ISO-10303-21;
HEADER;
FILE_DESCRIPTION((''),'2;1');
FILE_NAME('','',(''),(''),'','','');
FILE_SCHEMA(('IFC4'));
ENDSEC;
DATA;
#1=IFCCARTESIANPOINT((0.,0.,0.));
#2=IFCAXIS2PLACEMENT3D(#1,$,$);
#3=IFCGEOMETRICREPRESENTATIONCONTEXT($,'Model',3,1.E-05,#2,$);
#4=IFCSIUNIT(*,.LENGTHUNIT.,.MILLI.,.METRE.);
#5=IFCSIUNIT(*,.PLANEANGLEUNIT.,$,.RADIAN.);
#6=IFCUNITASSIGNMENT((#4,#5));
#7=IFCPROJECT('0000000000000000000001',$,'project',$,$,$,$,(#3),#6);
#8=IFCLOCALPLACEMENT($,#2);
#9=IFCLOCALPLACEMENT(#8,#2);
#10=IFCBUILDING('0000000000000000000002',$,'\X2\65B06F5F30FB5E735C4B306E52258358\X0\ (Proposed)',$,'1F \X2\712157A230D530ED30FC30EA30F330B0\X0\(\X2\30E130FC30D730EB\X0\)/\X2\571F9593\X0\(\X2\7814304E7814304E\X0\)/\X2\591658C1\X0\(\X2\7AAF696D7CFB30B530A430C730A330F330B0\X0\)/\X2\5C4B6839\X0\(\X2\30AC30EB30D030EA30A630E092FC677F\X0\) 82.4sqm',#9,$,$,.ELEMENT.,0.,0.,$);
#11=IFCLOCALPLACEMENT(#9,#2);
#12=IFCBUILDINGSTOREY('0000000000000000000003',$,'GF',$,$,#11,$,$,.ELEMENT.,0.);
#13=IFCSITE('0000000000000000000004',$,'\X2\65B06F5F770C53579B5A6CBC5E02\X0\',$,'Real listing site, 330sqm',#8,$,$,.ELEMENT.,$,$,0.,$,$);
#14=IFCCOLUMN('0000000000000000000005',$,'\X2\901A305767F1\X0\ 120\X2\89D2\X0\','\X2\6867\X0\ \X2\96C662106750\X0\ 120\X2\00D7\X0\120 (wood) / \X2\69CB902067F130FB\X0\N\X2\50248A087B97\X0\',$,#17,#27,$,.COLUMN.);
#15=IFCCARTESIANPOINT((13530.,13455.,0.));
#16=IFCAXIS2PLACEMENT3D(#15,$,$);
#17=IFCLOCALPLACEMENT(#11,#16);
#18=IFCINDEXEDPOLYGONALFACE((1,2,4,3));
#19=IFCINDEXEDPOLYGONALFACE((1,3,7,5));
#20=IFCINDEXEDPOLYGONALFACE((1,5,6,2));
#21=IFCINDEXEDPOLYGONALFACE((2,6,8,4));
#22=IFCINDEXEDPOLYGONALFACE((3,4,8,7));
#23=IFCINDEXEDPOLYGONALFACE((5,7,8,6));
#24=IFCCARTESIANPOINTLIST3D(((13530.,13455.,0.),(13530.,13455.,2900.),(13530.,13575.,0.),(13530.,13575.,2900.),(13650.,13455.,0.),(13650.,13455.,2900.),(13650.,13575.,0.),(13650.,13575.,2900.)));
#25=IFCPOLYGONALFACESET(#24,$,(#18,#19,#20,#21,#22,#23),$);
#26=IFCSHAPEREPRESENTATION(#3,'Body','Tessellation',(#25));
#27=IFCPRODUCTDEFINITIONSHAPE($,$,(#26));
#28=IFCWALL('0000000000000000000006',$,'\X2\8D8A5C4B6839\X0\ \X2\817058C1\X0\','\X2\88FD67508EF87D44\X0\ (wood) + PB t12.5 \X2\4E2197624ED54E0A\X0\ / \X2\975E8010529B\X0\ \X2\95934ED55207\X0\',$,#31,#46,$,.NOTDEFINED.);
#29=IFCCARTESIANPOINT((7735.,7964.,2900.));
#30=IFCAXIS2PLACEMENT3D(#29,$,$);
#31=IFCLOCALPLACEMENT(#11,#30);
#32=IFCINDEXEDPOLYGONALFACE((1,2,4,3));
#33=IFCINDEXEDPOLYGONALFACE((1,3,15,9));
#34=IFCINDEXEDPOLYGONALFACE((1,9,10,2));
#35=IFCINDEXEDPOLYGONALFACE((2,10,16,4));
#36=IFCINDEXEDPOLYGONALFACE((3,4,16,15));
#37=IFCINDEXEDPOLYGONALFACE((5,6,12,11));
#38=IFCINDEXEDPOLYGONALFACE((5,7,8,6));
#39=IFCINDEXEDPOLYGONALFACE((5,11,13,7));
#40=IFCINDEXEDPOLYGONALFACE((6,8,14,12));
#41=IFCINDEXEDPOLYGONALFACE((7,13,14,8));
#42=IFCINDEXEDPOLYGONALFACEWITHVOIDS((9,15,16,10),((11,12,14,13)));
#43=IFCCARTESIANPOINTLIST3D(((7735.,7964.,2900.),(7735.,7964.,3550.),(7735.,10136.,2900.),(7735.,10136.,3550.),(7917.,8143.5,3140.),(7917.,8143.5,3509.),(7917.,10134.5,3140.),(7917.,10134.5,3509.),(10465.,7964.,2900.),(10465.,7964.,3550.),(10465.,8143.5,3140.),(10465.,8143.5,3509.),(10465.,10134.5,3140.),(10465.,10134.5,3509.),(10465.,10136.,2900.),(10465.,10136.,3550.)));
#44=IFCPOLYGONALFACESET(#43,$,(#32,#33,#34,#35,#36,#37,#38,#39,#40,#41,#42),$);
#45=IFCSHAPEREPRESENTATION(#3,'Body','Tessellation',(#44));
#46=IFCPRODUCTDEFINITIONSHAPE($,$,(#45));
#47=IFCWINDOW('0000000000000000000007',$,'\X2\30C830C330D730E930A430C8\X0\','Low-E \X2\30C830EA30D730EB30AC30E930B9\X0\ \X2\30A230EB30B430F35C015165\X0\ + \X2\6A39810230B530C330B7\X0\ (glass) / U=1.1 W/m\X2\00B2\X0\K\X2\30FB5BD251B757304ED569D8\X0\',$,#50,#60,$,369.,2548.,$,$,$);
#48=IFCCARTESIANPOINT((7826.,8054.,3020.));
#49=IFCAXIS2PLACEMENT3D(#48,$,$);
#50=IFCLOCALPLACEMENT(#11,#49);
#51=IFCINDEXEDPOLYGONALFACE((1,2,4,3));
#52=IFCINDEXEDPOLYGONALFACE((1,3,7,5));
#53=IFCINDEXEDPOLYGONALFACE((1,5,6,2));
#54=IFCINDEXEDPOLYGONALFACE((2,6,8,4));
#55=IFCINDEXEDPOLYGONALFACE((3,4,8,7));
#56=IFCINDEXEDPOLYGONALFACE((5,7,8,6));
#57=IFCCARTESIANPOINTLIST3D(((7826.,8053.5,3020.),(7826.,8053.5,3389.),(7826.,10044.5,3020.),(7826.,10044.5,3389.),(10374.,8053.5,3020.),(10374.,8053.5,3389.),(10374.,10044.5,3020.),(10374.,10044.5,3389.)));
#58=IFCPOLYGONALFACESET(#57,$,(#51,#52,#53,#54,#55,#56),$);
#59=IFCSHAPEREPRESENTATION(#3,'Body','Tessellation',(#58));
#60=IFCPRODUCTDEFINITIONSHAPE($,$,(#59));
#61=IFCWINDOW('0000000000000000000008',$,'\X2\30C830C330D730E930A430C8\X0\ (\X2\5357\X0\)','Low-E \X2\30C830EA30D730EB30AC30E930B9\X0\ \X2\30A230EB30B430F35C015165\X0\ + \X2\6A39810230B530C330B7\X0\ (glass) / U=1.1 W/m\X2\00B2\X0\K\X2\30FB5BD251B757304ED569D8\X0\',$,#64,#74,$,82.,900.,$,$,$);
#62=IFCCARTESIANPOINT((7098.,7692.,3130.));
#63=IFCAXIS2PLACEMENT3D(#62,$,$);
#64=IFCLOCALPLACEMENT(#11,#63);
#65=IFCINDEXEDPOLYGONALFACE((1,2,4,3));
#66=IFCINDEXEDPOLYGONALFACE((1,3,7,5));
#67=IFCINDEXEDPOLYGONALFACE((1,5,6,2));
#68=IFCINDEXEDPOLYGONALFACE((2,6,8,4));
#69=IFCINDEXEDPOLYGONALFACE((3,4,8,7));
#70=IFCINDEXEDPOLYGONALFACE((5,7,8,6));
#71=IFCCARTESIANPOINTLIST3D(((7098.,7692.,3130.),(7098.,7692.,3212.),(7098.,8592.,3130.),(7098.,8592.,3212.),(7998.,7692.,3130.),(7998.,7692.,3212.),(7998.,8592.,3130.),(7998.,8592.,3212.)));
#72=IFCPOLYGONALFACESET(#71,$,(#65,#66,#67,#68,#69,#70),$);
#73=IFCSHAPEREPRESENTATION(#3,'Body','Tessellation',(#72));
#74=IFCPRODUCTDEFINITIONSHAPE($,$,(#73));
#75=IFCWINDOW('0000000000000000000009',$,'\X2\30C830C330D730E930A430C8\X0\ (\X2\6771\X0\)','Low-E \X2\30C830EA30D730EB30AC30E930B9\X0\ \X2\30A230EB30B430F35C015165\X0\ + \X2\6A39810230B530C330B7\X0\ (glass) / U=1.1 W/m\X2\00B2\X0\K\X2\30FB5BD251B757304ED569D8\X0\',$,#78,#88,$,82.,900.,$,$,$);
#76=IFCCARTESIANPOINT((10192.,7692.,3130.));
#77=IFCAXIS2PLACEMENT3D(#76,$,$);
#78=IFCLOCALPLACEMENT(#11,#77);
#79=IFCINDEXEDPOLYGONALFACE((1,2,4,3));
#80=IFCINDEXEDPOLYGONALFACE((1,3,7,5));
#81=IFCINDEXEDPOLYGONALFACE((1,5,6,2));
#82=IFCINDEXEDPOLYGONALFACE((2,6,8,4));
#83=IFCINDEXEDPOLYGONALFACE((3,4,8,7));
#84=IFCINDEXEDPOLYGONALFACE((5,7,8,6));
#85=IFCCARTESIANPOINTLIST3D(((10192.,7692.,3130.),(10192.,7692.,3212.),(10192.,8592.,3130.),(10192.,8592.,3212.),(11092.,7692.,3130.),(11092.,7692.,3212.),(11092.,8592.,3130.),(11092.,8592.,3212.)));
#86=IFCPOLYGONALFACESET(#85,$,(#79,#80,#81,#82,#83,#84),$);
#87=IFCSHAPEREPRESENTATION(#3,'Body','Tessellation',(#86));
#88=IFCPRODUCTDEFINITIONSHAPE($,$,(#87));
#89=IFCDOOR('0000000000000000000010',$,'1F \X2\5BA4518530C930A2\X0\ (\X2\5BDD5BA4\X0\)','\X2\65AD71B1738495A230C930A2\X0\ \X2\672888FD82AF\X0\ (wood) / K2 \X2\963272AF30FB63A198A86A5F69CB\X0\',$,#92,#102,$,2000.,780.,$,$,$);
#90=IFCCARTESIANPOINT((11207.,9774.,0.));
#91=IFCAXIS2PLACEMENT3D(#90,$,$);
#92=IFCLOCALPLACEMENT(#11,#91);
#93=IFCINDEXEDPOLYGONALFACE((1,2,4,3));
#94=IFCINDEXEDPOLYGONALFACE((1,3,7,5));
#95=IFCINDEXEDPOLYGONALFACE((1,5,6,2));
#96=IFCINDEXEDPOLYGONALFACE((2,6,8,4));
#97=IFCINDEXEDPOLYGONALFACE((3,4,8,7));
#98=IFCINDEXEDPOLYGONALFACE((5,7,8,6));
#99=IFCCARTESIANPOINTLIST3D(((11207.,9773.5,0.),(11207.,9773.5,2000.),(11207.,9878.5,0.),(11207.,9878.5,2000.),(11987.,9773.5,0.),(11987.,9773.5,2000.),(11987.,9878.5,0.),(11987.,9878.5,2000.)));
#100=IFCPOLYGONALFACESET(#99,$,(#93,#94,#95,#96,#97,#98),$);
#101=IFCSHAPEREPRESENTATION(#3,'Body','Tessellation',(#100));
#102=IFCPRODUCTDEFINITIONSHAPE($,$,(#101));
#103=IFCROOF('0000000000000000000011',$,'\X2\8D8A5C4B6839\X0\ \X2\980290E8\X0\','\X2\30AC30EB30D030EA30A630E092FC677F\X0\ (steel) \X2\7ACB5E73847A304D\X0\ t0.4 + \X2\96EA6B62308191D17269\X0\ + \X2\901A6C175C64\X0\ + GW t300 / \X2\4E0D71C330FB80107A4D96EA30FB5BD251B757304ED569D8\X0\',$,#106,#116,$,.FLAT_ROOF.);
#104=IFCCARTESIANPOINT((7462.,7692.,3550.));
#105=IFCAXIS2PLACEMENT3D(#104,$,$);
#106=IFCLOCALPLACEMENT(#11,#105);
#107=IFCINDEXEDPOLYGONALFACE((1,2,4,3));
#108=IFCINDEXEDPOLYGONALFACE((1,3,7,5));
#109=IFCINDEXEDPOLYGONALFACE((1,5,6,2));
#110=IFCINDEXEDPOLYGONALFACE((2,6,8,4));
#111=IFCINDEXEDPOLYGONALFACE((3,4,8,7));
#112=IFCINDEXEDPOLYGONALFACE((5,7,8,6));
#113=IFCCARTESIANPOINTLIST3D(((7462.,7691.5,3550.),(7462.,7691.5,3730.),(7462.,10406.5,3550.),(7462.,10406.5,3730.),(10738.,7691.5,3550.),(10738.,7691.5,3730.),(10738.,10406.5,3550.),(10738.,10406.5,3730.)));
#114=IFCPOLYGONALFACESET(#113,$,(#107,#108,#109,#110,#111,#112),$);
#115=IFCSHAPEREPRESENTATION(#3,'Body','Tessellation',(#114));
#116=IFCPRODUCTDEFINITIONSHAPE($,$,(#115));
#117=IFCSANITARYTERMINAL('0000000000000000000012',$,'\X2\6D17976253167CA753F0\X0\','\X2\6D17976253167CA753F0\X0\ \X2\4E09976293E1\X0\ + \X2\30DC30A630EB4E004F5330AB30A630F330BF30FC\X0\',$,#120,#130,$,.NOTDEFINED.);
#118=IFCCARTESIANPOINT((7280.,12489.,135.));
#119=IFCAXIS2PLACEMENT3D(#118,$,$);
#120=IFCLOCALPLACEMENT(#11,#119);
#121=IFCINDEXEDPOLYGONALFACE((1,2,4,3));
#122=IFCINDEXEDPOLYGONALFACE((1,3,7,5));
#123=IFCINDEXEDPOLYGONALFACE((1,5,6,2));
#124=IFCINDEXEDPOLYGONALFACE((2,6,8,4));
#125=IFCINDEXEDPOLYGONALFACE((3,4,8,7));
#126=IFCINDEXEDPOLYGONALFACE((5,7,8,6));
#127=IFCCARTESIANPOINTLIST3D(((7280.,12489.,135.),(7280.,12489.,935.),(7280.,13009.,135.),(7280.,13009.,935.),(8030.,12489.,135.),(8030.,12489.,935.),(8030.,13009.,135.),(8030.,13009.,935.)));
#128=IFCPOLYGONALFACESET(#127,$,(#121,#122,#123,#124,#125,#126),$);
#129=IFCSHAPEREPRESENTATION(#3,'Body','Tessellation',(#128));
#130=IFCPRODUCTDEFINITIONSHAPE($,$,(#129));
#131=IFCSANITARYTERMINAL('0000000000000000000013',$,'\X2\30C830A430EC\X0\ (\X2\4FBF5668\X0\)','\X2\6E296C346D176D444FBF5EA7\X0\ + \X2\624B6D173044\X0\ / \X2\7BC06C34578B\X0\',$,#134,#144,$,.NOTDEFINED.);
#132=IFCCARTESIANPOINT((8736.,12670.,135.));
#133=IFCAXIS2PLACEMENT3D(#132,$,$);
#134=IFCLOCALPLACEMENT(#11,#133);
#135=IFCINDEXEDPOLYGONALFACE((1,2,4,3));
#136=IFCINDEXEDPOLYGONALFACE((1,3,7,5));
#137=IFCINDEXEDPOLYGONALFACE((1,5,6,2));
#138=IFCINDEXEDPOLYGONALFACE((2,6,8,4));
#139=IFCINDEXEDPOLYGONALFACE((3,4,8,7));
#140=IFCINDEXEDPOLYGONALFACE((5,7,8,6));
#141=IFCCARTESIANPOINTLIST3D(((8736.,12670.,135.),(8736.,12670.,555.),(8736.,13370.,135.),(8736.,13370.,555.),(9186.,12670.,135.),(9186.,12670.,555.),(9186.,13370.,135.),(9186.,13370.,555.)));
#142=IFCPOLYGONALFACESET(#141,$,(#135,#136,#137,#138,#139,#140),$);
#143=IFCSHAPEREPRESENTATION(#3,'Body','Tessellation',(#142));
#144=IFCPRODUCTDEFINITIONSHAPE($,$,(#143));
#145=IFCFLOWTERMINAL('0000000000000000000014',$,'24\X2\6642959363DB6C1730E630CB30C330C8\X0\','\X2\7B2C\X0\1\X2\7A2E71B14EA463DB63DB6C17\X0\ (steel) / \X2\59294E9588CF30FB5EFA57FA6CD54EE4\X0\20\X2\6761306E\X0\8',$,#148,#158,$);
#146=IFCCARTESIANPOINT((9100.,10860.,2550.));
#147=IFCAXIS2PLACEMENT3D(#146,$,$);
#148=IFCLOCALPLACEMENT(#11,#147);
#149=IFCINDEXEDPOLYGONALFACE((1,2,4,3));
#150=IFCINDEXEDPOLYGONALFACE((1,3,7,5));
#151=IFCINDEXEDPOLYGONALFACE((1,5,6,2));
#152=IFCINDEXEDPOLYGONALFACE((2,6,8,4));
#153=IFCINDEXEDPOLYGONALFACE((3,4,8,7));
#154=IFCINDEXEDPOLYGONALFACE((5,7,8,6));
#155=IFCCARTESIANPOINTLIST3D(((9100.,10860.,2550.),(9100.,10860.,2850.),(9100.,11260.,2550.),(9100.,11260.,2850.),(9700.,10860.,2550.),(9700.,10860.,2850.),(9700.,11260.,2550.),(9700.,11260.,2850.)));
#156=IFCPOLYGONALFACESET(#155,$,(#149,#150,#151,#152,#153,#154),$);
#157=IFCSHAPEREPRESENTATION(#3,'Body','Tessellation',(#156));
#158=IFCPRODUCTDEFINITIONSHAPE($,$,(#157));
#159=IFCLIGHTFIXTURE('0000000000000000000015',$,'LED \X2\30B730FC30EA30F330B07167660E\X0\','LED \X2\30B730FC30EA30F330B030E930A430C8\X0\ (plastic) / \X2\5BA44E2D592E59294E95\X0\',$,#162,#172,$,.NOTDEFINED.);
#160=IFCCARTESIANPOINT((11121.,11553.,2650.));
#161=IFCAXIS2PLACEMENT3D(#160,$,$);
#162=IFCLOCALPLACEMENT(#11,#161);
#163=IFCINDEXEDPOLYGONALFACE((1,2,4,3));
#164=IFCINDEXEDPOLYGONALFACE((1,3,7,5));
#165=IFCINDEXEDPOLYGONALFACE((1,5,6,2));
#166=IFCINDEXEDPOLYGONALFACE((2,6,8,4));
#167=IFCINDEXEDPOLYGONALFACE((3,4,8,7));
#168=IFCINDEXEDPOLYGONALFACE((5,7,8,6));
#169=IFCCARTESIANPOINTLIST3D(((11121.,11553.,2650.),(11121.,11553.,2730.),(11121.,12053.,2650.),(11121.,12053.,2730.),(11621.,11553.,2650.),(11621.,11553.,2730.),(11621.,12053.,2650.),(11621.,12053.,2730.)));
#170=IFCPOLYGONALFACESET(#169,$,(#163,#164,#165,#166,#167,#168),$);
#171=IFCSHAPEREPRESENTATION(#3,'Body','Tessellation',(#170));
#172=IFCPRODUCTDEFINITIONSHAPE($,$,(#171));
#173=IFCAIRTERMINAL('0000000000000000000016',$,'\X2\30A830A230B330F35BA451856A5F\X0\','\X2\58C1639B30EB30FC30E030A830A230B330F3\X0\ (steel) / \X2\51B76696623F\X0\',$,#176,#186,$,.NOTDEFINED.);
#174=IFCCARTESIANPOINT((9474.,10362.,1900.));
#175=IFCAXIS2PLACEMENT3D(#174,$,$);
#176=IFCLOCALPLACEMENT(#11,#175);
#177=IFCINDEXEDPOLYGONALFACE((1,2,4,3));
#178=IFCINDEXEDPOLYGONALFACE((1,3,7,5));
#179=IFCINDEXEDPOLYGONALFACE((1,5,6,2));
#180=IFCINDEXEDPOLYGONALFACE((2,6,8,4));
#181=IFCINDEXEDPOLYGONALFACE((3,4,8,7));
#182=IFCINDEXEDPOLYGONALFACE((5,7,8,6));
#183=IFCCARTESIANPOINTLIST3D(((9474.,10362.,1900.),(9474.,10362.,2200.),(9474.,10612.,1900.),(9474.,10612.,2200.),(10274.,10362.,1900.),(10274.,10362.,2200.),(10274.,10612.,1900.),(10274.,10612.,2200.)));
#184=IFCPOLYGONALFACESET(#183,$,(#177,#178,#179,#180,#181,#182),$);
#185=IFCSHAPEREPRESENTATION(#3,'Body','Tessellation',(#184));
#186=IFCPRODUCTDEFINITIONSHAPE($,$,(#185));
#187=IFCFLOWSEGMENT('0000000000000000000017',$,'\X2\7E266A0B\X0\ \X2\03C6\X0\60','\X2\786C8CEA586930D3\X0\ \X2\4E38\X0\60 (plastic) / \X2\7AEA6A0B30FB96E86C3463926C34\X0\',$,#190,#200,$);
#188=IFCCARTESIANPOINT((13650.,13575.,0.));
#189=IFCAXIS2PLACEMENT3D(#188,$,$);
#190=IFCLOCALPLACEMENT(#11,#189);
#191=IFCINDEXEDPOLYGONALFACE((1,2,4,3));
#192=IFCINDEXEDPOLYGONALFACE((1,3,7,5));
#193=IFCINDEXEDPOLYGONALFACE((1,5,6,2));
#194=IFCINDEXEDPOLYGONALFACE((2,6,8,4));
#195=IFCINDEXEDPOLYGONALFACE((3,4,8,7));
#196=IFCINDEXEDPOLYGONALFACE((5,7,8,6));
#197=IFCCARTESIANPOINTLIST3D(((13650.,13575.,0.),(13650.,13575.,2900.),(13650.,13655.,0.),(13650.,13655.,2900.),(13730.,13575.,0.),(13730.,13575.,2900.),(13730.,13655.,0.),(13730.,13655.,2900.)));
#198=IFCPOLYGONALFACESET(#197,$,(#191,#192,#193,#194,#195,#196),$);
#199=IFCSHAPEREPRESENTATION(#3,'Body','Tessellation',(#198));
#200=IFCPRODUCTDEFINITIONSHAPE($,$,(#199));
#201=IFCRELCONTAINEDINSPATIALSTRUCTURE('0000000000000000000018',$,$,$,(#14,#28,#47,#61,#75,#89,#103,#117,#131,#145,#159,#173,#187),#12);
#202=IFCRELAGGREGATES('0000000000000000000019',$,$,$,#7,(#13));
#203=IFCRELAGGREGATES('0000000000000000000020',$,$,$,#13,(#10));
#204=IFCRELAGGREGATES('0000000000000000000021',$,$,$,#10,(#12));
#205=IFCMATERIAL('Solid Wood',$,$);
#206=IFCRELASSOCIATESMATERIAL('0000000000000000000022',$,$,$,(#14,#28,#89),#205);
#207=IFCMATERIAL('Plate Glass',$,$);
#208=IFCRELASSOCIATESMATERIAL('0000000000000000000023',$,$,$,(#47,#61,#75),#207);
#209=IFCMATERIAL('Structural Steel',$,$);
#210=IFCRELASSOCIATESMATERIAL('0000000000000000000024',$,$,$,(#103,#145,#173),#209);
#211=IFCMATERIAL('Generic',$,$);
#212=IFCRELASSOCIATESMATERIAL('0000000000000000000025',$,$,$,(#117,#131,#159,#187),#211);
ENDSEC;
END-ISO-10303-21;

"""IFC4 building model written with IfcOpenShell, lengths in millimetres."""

from ifc_helpers import new_model, si_unit, frame, frame_2d, origin, place, context, project, spatial, rectangle, extrude, material, element, fill, save


model = new_model("IFC4")

# Units and contexts
model_context = context("Model", 3, precision=1e-05, world=origin())
ifc_project = project(units=[si_unit("LENGTHUNIT", "METRE", prefix="MILLI"), si_unit("PLANEANGLEUNIT", "RADIAN")], contexts=[model_context])

# Site, building, storey
site_placement = place(None, origin())
site = spatial("IfcSite", under=ifc_project, at=site_placement, Name="新潟県南魚沼市", ObjectType="Real listing site, 330sqm", CompositionType="ELEMENT", RefElevation=0.0)
building_placement = place(site_placement, origin())
building = spatial("IfcBuilding", under=site, at=building_placement, Name="新潟・平屋の別荘 (Proposed)", ObjectType="1F 無垢フローリング(メープル)/土間(研ぎ研ぎ)/外壁(窯業系サイディング)/屋根(ガルバリウム鋼板) 82.4sqm", CompositionType="ELEMENT", ElevationOfRefHeight=0.0, ElevationOfTerrain=0.0)
storey_placement = place(building_placement, origin())
storey = spatial("IfcBuildingStorey", under=building, at=storey_placement, Name="GF", CompositionType="ELEMENT", Elevation=0.0)

# Column
ifc_material_1 = material(Name="Solid Wood")
column_1_placement = place(storey_placement, frame((13530.0, 13455.0, 0.0)))
element("IfcColumn", 1, at=column_1_placement, inside=storey, material=ifc_material_1, Name="通し柱 120角", Description="桧 集成材 120×120 (wood) / 構造柱・N値計算", PredefinedType="COLUMN", context=model_context, shape_type="SweptSolid", body=[
    extrude(rectangle(XDim=120.0, YDim=120.0, at=frame_2d((60.0, 60.0))), frame((13530.0, 13455.0, 0.0)), (0.0, 0.0, 1.0), 2900.0),
])

# Wall, openings, windows
wall_1_placement = place(storey_placement, frame((7735.0, 7964.0, 2900.0)))
wall_1 = element("IfcWall", 2, at=wall_1_placement, inside=storey, material=ifc_material_1, Name="越屋根 腰壁", Description="製材軸組 (wood) + PB t12.5 両面仕上 / 非耐力 間仕切", PredefinedType="NOTDEFINED", context=model_context, shape_type="SweptSolid", body=[
    extrude(rectangle(XDim=2730.0, YDim=2172.0, at=frame_2d((1365.0, 1086.0))), frame((7735.0, 7964.0, 2900.0)), (0.0, 0.0, 1.0), 650.0),
])
opening_1_placement = place(storey_placement, frame((7826.0, 8054.0, 3020.0)))
opening_1 = element("IfcOpeningElement", 3, at=opening_1_placement, cuts=wall_1, PredefinedType="NOTDEFINED", context=model_context, shape_type="SweptSolid", body=[
    extrude(rectangle(XDim=2548.0, YDim=1991.0, at=frame_2d((1274.0, 995.0))), frame((7826.0, 8054.0, 3020.0)), (0.0, 0.0, 1.0), 369.0),
])
opening_2_placement = place(storey_placement, frame((7098.0, 7692.0, 3130.0)))
opening_2 = element("IfcOpeningElement", 4, at=opening_2_placement, cuts=wall_1, PredefinedType="NOTDEFINED", context=model_context, shape_type="SweptSolid", body=[
    extrude(rectangle(XDim=900.0, YDim=900.0, at=frame_2d((450.0, 450.0))), frame((7098.0, 7692.0, 3130.0)), (0.0, 0.0, 1.0), 82.0),
])
opening_3_placement = place(storey_placement, frame((10192.0, 7692.0, 3130.0)))
opening_3 = element("IfcOpeningElement", 5, at=opening_3_placement, cuts=wall_1, PredefinedType="NOTDEFINED", context=model_context, shape_type="SweptSolid", body=[
    extrude(rectangle(XDim=900.0, YDim=900.0, at=frame_2d((450.0, 450.0))), frame((10192.0, 7692.0, 3130.0)), (0.0, 0.0, 1.0), 82.0),
])
ifc_material_2 = material(Name="Plate Glass")
window_1_placement = place(storey_placement, frame((7826.0, 8054.0, 3020.0)))
window_1 = element("IfcWindow", 6, at=window_1_placement, inside=storey, material=ifc_material_2, Name="トップライト", Description="Low-E トリプルガラス アルゴン封入 + 樹脂サッシ (glass) / U=1.1 W/m²K・寒冷地仕様", OverallHeight=369.0, OverallWidth=2548.0, context=model_context, shape_type="SweptSolid", body=[
    extrude(rectangle(XDim=2548.0, YDim=1991.0, at=frame_2d((1274.0, 995.0))), frame((7826.0, 8054.0, 3020.0)), (0.0, 0.0, 1.0), 369.0),
])
fill(opening_1, window_1)
window_2_placement = place(storey_placement, frame((7098.0, 7692.0, 3130.0)))
window_2 = element("IfcWindow", 7, at=window_2_placement, inside=storey, material=ifc_material_2, Name="トップライト (南)", Description="Low-E トリプルガラス アルゴン封入 + 樹脂サッシ (glass) / U=1.1 W/m²K・寒冷地仕様", OverallHeight=82.0, OverallWidth=900.0, context=model_context, shape_type="SweptSolid", body=[
    extrude(rectangle(XDim=900.0, YDim=900.0, at=frame_2d((450.0, 450.0))), frame((7098.0, 7692.0, 3130.0)), (0.0, 0.0, 1.0), 82.0),
])
fill(opening_2, window_2)
window_3_placement = place(storey_placement, frame((10192.0, 7692.0, 3130.0)))
window_3 = element("IfcWindow", 8, at=window_3_placement, inside=storey, material=ifc_material_2, Name="トップライト (東)", Description="Low-E トリプルガラス アルゴン封入 + 樹脂サッシ (glass) / U=1.1 W/m²K・寒冷地仕様", OverallHeight=82.0, OverallWidth=900.0, context=model_context, shape_type="SweptSolid", body=[
    extrude(rectangle(XDim=900.0, YDim=900.0, at=frame_2d((450.0, 450.0))), frame((10192.0, 7692.0, 3130.0)), (0.0, 0.0, 1.0), 82.0),
])
fill(opening_3, window_3)

# Door
door_placement = place(storey_placement, frame((11207.0, 9774.0, 0.0)))
element("IfcDoor", 9, at=door_placement, inside=storey, material=ifc_material_1, Name="1F 室内ドア (寝室)", Description="断熱玄関ドア 木製芯 (wood) / K2 防犯・採風機構", OverallHeight=2000.0, OverallWidth=780.0, context=model_context, shape_type="SweptSolid", body=[
    extrude(rectangle(XDim=780.0, YDim=105.0, at=frame_2d((390.0, 52.0))), frame((11207.0, 9774.0, 0.0)), (0.0, 0.0, 1.0), 2000.0),
])

# Roof
ifc_material_3 = material(Name="Structural Steel")
roof_placement = place(storey_placement, frame((7462.0, 7692.0, 3550.0)))
element("IfcRoof", 10, at=roof_placement, inside=storey, material=ifc_material_3, Name="越屋根 頂部", Description="ガルバリウム鋼板 (steel) 立平葺き t0.4 + 雪止め金物 + 通気層 + GW t300 / 不燃・耐積雪・寒冷地仕様", PredefinedType="FLAT_ROOF", context=model_context, shape_type="SweptSolid", body=[
    extrude(rectangle(XDim=3276.0, YDim=2715.0, at=frame_2d((1638.0, 1357.0))), frame((7462.0, 7692.0, 3550.0)), (0.0, 0.0, 1.0), 180.0),
])

# Sanitary terminals
ifc_material_4 = material(Name="Generic")
sanitary_terminal_1_placement = place(storey_placement, frame((7280.0, 12489.0, 135.0)))
element("IfcSanitaryTerminal", 11, at=sanitary_terminal_1_placement, inside=storey, material=ifc_material_4, Name="洗面化粧台", Description="洗面化粧台 三面鏡 + ボウル一体カウンター", PredefinedType="NOTDEFINED", context=model_context, shape_type="SweptSolid", body=[
    extrude(rectangle(XDim=750.0, YDim=520.0, at=frame_2d((375.0, 260.0))), frame((7280.0, 12489.0, 135.0)), (0.0, 0.0, 1.0), 800.0),
])
sanitary_terminal_2_placement = place(storey_placement, frame((8736.0, 12670.0, 135.0)))
element("IfcSanitaryTerminal", 12, at=sanitary_terminal_2_placement, inside=storey, material=ifc_material_4, Name="トイレ (便器)", Description="温水洗浄便座 + 手洗い / 節水型", PredefinedType="NOTDEFINED", context=model_context, shape_type="SweptSolid", body=[
    extrude(rectangle(XDim=450.0, YDim=700.0, at=frame_2d((225.0, 350.0))), frame((8736.0, 12670.0, 135.0)), (0.0, 0.0, 1.0), 420.0),
])

# Flow terminal
flow_terminal_placement = place(storey_placement, frame((9100.0, 10860.0, 2550.0)))
element("IfcFlowTerminal", 13, at=flow_terminal_placement, inside=storey, material=ifc_material_3, Name="24時間換気ユニット", Description="第1種熱交換換気 (steel) / 天井裏・建基法令20条の8", context=model_context, shape_type="SweptSolid", body=[
    extrude(rectangle(XDim=600.0, YDim=400.0, at=frame_2d((300.0, 200.0))), frame((9100.0, 10860.0, 2550.0)), (0.0, 0.0, 1.0), 300.0),
])

# Light fixture
light_fixture_placement = place(storey_placement, frame((11121.0, 11553.0, 2650.0)))
element("IfcLightFixture", 14, at=light_fixture_placement, inside=storey, material=ifc_material_4, Name="LED シーリング照明", Description="LED シーリングライト (plastic) / 室中央天井", PredefinedType="NOTDEFINED", context=model_context, shape_type="SweptSolid", body=[
    extrude(rectangle(XDim=500.0, YDim=500.0, at=frame_2d((250.0, 250.0))), frame((11121.0, 11553.0, 2650.0)), (0.0, 0.0, 1.0), 80.0),
])

# Air terminal
air_terminal_placement = place(storey_placement, frame((9474.0, 10362.0, 1900.0)))
element("IfcAirTerminal", 15, at=air_terminal_placement, inside=storey, material=ifc_material_3, Name="エアコン室内機", Description="壁掛ルームエアコン (steel) / 冷暖房", PredefinedType="NOTDEFINED", context=model_context, shape_type="SweptSolid", body=[
    extrude(rectangle(XDim=800.0, YDim=250.0, at=frame_2d((400.0, 125.0))), frame((9474.0, 10362.0, 1900.0)), (0.0, 0.0, 1.0), 300.0),
])

# Flow segment
flow_segment_placement = place(storey_placement, frame((13650.0, 13575.0, 0.0)))
element("IfcFlowSegment", 16, at=flow_segment_placement, inside=storey, material=ifc_material_4, Name="縦樋 φ60", Description="硬質塩ビ 丸60 (plastic) / 竪樋・雨水排水", context=model_context, shape_type="SweptSolid", body=[
    extrude(rectangle(XDim=80.0, YDim=80.0, at=frame_2d((40.0, 40.0))), frame((13650.0, 13575.0, 0.0)), (0.0, 0.0, 1.0), 2900.0),
])

save(model, "model.ifc")
